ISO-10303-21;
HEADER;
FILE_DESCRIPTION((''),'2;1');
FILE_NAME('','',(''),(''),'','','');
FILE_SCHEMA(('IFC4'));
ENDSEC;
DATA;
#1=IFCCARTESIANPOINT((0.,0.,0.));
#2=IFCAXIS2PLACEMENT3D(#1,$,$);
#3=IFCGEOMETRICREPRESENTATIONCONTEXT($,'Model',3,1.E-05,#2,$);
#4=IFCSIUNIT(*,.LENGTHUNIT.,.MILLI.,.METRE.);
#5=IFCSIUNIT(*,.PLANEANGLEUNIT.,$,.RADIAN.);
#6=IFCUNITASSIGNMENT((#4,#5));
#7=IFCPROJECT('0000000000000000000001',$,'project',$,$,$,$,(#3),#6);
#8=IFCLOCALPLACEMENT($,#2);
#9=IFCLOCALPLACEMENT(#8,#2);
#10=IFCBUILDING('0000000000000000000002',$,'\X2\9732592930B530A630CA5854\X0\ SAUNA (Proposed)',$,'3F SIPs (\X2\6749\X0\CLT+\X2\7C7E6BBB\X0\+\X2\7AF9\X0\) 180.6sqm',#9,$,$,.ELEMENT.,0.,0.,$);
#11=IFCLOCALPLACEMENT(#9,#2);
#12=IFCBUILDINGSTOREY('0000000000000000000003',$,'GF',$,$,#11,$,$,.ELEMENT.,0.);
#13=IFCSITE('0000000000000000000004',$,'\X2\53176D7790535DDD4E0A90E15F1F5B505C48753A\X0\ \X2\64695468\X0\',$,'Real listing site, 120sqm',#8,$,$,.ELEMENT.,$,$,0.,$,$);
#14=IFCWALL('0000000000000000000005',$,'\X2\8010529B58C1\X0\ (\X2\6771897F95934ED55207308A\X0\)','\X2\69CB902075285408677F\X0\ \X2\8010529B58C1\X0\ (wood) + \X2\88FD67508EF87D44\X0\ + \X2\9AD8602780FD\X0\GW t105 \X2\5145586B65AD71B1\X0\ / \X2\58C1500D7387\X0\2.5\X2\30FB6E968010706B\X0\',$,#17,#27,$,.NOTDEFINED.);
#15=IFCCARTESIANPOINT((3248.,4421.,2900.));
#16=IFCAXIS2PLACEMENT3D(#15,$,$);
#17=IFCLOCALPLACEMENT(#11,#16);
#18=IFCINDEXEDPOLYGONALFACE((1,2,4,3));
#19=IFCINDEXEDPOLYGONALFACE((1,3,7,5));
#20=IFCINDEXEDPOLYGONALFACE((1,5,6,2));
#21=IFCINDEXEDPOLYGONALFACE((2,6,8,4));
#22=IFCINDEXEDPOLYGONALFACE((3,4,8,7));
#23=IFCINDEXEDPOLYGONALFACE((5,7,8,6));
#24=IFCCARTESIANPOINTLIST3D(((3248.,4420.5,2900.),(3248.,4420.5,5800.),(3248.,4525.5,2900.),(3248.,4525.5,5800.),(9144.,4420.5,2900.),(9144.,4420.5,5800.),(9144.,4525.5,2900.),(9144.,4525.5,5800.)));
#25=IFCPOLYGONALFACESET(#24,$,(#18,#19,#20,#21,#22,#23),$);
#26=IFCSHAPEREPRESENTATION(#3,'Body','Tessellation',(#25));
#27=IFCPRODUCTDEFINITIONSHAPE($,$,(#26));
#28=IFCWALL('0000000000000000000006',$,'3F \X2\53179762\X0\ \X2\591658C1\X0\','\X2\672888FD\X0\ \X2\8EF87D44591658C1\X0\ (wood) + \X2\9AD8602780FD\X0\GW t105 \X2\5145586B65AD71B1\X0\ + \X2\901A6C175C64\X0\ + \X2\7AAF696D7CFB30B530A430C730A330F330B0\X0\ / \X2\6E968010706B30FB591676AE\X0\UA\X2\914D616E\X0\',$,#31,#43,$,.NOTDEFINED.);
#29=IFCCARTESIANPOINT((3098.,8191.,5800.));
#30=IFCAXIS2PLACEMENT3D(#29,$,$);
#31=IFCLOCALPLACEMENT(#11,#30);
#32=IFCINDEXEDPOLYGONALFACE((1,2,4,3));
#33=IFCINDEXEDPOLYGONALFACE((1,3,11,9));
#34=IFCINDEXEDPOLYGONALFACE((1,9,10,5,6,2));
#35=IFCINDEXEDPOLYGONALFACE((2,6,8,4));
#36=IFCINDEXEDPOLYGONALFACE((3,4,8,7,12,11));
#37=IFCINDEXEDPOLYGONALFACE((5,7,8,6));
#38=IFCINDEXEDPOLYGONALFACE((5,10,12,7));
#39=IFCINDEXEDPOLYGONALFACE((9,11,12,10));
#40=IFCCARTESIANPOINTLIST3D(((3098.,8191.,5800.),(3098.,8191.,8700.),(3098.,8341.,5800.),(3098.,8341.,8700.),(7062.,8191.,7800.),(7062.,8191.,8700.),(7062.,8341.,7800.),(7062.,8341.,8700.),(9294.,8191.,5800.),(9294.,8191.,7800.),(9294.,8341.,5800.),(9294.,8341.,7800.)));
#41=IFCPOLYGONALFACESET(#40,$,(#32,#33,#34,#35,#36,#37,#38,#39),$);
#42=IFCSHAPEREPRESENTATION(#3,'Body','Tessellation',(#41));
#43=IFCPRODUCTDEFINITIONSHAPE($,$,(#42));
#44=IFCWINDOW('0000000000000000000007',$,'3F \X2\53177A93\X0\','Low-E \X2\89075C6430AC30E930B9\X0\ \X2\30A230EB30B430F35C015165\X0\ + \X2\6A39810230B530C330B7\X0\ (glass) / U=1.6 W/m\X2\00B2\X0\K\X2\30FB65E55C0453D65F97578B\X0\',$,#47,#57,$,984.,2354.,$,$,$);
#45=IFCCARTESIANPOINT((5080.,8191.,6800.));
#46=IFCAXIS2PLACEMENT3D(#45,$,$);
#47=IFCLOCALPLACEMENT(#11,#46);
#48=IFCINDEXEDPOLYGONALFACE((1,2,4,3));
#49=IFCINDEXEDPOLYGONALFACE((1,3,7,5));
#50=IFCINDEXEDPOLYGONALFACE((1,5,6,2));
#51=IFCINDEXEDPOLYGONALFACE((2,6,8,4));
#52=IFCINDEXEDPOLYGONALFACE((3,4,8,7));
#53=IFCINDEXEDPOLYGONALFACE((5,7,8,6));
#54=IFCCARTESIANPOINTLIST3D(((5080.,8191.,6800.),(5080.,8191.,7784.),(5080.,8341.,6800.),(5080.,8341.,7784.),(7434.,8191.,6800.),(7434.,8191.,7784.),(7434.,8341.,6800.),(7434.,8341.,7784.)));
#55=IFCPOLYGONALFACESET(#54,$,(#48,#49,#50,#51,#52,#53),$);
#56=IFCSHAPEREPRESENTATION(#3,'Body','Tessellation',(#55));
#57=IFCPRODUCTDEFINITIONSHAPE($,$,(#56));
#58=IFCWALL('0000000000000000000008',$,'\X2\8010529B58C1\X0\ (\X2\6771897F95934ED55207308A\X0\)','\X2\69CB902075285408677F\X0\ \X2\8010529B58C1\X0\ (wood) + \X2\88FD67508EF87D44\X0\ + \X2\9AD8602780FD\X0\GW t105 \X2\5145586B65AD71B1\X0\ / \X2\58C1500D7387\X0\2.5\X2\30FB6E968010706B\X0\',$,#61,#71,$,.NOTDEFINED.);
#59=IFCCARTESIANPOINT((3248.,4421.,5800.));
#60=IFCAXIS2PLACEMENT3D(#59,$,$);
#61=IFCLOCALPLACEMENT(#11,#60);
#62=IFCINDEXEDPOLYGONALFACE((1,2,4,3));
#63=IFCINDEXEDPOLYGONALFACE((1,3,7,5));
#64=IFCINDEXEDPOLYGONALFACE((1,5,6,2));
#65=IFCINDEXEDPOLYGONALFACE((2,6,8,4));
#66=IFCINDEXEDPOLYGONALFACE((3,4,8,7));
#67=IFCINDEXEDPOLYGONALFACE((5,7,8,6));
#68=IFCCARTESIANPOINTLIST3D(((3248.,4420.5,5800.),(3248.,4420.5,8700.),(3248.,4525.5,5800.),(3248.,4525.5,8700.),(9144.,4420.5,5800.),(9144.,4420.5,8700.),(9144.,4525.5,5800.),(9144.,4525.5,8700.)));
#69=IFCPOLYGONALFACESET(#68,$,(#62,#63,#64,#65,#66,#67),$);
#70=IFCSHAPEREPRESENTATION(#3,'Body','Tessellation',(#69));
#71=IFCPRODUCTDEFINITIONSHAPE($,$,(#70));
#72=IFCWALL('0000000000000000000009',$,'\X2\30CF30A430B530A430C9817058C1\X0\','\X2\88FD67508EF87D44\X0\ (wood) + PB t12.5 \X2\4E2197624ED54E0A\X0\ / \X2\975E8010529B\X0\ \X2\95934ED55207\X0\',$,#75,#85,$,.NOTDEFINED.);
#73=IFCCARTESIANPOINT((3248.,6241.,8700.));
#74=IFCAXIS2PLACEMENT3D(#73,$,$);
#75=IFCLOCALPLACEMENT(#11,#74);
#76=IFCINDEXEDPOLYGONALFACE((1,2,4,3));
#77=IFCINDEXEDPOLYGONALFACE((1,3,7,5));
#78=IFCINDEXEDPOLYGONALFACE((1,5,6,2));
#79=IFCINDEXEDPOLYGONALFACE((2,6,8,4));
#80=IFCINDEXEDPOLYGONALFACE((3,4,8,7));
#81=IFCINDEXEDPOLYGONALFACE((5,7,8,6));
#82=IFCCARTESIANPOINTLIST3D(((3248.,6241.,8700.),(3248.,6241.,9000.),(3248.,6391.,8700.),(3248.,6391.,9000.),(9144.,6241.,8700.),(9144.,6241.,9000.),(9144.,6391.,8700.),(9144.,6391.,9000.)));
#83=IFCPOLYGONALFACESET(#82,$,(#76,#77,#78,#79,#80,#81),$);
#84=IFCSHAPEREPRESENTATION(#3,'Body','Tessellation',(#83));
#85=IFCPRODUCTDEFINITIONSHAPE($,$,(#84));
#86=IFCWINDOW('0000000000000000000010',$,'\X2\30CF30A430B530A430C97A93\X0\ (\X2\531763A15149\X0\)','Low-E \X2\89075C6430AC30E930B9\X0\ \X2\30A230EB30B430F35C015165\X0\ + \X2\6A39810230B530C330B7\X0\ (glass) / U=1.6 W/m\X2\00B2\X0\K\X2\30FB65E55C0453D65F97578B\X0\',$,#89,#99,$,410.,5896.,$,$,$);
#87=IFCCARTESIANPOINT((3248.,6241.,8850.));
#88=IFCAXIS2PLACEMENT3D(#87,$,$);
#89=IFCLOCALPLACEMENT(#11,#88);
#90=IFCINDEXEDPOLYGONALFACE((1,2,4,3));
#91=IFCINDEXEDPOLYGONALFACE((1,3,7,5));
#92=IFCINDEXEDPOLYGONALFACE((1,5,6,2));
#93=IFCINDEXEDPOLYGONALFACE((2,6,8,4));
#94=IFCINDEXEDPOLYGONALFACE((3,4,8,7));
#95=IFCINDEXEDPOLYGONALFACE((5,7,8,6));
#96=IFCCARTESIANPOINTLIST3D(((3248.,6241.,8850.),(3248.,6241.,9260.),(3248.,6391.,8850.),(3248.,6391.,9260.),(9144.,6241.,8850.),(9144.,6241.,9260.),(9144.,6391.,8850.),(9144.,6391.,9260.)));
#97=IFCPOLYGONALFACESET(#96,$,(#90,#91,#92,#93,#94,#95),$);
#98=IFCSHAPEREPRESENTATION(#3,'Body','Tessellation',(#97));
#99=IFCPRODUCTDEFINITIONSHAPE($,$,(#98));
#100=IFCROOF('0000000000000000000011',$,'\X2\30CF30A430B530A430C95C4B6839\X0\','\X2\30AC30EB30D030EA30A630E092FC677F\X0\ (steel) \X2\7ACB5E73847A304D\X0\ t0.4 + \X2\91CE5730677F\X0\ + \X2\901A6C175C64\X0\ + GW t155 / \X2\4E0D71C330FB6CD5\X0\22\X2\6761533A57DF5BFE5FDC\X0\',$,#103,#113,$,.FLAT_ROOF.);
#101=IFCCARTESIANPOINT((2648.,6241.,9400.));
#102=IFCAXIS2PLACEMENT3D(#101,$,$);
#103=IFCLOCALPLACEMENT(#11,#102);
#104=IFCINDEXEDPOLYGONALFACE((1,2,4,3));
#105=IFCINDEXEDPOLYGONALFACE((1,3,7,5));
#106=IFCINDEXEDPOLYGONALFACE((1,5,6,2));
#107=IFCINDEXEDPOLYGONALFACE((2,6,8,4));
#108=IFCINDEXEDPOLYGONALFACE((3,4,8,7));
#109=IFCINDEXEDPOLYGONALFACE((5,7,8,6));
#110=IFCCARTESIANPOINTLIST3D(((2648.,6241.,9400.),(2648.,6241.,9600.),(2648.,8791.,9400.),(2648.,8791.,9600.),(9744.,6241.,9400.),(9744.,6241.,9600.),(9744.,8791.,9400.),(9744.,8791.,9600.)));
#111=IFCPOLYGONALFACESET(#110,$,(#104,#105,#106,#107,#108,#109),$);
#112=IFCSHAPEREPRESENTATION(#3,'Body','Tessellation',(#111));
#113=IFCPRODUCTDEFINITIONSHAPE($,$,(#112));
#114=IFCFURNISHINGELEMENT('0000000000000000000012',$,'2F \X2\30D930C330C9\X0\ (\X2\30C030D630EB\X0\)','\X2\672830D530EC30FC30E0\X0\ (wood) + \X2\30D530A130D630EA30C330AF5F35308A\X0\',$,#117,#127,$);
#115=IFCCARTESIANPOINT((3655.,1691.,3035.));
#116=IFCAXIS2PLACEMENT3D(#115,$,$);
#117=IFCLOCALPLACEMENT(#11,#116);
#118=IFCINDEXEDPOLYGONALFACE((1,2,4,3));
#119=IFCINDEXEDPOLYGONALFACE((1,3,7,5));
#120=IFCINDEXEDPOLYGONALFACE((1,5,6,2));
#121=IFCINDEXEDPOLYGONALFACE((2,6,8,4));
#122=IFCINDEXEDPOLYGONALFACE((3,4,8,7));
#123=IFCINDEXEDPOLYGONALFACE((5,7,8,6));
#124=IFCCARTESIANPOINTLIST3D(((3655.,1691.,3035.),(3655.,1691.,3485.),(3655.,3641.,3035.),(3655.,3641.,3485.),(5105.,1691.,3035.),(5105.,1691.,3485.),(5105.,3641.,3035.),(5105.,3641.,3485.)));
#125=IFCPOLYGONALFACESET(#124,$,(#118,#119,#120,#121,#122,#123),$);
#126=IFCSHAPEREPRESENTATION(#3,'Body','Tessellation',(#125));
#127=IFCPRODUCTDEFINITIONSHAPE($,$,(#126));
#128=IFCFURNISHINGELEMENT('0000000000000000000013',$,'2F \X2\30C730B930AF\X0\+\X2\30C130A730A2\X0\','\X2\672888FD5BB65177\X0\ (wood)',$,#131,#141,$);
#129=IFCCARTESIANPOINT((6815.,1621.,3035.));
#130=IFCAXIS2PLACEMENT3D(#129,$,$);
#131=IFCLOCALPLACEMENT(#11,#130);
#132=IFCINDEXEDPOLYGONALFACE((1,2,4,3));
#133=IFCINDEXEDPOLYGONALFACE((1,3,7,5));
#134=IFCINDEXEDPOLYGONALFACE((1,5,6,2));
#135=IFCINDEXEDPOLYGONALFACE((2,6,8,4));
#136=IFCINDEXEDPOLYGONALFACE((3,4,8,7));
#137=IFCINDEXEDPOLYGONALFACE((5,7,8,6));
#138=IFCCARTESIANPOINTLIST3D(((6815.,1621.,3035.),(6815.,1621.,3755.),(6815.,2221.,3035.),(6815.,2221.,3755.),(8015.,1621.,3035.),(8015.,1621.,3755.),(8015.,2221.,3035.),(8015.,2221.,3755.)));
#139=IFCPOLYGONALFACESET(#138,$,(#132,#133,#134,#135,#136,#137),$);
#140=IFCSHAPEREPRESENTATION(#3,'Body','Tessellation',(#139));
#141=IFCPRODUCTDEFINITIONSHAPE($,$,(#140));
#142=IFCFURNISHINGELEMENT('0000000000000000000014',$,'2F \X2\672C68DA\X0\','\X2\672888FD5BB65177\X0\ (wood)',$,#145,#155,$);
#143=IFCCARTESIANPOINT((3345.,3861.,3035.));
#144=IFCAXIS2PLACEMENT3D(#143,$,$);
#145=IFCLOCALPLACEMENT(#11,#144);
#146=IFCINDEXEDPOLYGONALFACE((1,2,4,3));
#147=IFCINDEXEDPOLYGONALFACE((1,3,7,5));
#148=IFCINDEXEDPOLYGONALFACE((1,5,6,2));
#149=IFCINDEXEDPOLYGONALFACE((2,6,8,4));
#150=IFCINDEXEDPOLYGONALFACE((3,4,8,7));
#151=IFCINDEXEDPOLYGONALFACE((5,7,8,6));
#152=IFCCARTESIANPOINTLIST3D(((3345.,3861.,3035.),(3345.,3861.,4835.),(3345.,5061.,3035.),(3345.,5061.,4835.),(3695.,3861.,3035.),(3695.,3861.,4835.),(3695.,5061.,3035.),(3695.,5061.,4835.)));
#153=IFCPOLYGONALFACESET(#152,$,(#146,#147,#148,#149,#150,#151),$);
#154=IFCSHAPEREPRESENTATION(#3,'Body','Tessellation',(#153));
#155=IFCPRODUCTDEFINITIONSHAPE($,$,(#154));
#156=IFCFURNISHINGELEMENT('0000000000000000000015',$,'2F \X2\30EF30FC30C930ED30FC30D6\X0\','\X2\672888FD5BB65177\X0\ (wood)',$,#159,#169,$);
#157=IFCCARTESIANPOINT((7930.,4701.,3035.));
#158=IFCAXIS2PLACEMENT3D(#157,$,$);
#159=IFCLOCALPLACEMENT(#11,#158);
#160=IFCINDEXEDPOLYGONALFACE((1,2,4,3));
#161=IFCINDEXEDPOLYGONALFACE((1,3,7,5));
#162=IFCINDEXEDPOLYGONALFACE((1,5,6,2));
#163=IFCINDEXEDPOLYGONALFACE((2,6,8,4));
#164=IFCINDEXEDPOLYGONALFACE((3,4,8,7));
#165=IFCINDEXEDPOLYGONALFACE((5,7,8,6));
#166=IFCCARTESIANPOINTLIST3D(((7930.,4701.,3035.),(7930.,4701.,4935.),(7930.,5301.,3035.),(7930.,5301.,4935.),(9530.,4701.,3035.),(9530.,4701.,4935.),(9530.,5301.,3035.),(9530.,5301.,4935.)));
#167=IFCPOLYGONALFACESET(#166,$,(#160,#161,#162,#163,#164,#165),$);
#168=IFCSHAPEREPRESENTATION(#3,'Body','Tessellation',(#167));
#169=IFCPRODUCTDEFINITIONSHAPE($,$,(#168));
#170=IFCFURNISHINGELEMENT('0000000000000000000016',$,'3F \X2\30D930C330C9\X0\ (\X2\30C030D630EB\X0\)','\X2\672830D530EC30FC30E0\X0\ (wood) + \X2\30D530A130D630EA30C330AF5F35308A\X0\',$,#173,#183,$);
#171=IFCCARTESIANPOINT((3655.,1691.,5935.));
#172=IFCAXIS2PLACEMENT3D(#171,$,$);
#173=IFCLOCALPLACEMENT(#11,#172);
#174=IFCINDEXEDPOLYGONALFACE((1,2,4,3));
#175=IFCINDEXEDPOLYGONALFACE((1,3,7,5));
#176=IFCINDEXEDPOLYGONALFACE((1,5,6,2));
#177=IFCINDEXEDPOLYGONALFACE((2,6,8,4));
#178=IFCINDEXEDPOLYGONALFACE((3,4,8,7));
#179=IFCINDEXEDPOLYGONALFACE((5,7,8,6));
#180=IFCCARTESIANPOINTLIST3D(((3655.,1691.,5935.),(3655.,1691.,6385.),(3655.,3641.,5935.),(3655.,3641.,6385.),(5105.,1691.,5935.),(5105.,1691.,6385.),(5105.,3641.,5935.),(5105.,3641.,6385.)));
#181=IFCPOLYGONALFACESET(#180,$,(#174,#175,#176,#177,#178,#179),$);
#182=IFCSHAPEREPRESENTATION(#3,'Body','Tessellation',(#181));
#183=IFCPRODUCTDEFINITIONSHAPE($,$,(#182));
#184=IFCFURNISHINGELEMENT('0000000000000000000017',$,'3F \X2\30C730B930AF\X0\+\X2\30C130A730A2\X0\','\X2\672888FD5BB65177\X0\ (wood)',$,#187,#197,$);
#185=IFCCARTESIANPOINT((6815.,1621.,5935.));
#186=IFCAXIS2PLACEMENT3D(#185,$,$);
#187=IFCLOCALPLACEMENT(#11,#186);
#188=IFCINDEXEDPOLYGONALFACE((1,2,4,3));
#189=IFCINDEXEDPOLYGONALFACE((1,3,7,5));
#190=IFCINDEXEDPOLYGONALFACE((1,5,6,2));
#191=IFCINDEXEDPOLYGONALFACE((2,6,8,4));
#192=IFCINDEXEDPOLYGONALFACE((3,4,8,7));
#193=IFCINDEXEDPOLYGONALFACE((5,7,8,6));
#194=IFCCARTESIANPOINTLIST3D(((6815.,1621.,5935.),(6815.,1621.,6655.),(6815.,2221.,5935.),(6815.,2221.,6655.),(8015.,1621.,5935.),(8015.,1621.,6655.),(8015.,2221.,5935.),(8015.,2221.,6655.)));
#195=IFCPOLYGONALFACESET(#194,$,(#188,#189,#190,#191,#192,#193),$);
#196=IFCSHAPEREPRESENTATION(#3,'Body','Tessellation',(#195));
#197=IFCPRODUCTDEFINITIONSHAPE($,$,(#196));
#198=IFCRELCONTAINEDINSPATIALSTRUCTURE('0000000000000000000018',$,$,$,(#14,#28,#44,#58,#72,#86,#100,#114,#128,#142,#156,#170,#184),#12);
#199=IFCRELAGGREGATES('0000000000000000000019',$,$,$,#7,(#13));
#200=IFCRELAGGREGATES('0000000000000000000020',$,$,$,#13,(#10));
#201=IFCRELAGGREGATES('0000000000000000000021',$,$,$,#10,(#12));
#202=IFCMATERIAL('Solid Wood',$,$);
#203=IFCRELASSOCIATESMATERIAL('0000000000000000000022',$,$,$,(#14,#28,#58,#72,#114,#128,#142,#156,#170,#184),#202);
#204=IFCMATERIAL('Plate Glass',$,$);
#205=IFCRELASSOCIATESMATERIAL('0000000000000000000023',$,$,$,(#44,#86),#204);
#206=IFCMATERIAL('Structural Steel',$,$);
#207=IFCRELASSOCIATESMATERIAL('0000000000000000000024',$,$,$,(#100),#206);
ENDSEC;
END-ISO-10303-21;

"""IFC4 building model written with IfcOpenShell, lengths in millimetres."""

from ifc_helpers import new_model, si_unit, frame, frame_2d, origin, place, context, project, spatial, rectangle, extrude, material, element, fill, save


model = new_model("IFC4")

# Units and contexts
model_context = context("Model", 3, precision=1e-05, world=origin())
ifc_project = project(units=[si_unit("LENGTHUNIT", "METRE", prefix="MILLI"), si_unit("PLANEANGLEUNIT", "RADIAN")], contexts=[model_context])

# Site, building, storey
site_placement = place(None, origin())
site = spatial("IfcSite", under=ifc_project, at=site_placement, Name="北海道川上郡弟子屈町 摩周", ObjectType="Real listing site, 120sqm", CompositionType="ELEMENT", RefElevation=0.0)
building_placement = place(site_placement, origin())
building = spatial("IfcBuilding", under=site, at=building_placement, Name="露天サウナ塔 SAUNA (Proposed)", ObjectType="3F SIPs (杉CLT+籾殻+竹) 180.6sqm", CompositionType="ELEMENT", ElevationOfRefHeight=0.0, ElevationOfTerrain=0.0)
storey_placement = place(building_placement, origin())
storey = spatial("IfcBuildingStorey", under=building, at=storey_placement, Name="GF", CompositionType="ELEMENT", Elevation=0.0)

# Wall
ifc_material_1 = material(Name="Solid Wood")
wall_1_placement = place(storey_placement, frame((3248.0, 4421.0, 2900.0)))
element("IfcWall", 1, at=wall_1_placement, inside=storey, material=ifc_material_1, Name="耐力壁 (東西間仕切り)", Description="構造用合板 耐力壁 (wood) + 製材軸組 + 高性能GW t105 充填断熱 / 壁倍率2.5・準耐火", PredefinedType="NOTDEFINED", context=model_context, shape_type="SweptSolid", body=[
    extrude(rectangle(XDim=5896.0, YDim=105.0, at=frame_2d((2948.0, 52.0))), frame((3248.0, 4421.0, 2900.0)), (0.0, 0.0, 1.0), 2900.0),
])

# Wall, opening, window
wall_2_placement = place(storey_placement, frame((3098.0, 8191.0, 5800.0)))
wall_2 = element("IfcWall", 2, at=wall_2_placement, inside=storey, material=ifc_material_1, Name="3F 北面 外壁", Description="木製 軸組外壁 (wood) + 高性能GW t105 充填断熱 + 通気層 + 窯業系サイディング / 準耐火・外皮UA配慮", PredefinedType="NOTDEFINED", context=model_context, shape_type="SweptSolid", body=[
    extrude(rectangle(XDim=6196.0, YDim=150.0, at=frame_2d((3098.0, 75.0))), frame((3098.0, 8191.0, 5800.0)), (0.0, 0.0, 1.0), 2900.0),
])
opening_1_placement = place(storey_placement, frame((5080.0, 8191.0, 6800.0)))
opening_1 = element("IfcOpeningElement", 3, at=opening_1_placement, cuts=wall_2, PredefinedType="NOTDEFINED", context=model_context, shape_type="SweptSolid", body=[
    extrude(rectangle(XDim=2354.0, YDim=150.0, at=frame_2d((1177.0, 75.0))), frame((5080.0, 8191.0, 6800.0)), (0.0, 0.0, 1.0), 984.0),
])
ifc_material_2 = material(Name="Plate Glass")
window_1_placement = place(storey_placement, frame((5080.0, 8191.0, 6800.0)))
window_1 = element("IfcWindow", 4, at=window_1_placement, inside=storey, material=ifc_material_2, Name="3F 北窓", Description="Low-E 複層ガラス アルゴン封入 + 樹脂サッシ (glass) / U=1.6 W/m²K・日射取得型", OverallHeight=984.0, OverallWidth=2354.0, context=model_context, shape_type="SweptSolid", body=[
    extrude(rectangle(XDim=2354.0, YDim=150.0, at=frame_2d((1177.0, 75.0))), frame((5080.0, 8191.0, 6800.0)), (0.0, 0.0, 1.0), 984.0),
])
fill(opening_1, window_1)

# Wall
wall_3_placement = place(storey_placement, frame((3248.0, 4421.0, 5800.0)))
element("IfcWall", 5, at=wall_3_placement, inside=storey, material=ifc_material_1, Name="耐力壁 (東西間仕切り)", Description="構造用合板 耐力壁 (wood) + 製材軸組 + 高性能GW t105 充填断熱 / 壁倍率2.5・準耐火", PredefinedType="NOTDEFINED", context=model_context, shape_type="SweptSolid", body=[
    extrude(rectangle(XDim=5896.0, YDim=105.0, at=frame_2d((2948.0, 52.0))), frame((3248.0, 4421.0, 5800.0)), (0.0, 0.0, 1.0), 2900.0),
])

# Wall, opening, window
wall_4_placement = place(storey_placement, frame((3248.0, 6241.0, 8700.0)))
wall_4 = element("IfcWall", 6, at=wall_4_placement, inside=storey, material=ifc_material_1, Name="ハイサイド腰壁", Description="製材軸組 (wood) + PB t12.5 両面仕上 / 非耐力 間仕切", PredefinedType="NOTDEFINED", context=model_context, shape_type="SweptSolid", body=[
    extrude(rectangle(XDim=5896.0, YDim=150.0, at=frame_2d((2948.0, 75.0))), frame((3248.0, 6241.0, 8700.0)), (0.0, 0.0, 1.0), 700.0),
])
opening_2_placement = place(storey_placement, frame((3248.0, 6241.0, 8850.0)))
opening_2 = element("IfcOpeningElement", 7, at=opening_2_placement, cuts=wall_4, PredefinedType="NOTDEFINED", context=model_context, shape_type="SweptSolid", body=[
    extrude(rectangle(XDim=5896.0, YDim=150.0, at=frame_2d((2948.0, 75.0))), frame((3248.0, 6241.0, 8850.0)), (0.0, 0.0, 1.0), 410.0),
])
window_2_placement = place(storey_placement, frame((3248.0, 6241.0, 8850.0)))
window_2 = element("IfcWindow", 8, at=window_2_placement, inside=storey, material=ifc_material_2, Name="ハイサイド窓 (北採光)", Description="Low-E 複層ガラス アルゴン封入 + 樹脂サッシ (glass) / U=1.6 W/m²K・日射取得型", OverallHeight=410.0, OverallWidth=5896.0, context=model_context, shape_type="SweptSolid", body=[
    extrude(rectangle(XDim=5896.0, YDim=150.0, at=frame_2d((2948.0, 75.0))), frame((3248.0, 6241.0, 8850.0)), (0.0, 0.0, 1.0), 410.0),
])
fill(opening_2, window_2)

# Roof
ifc_material_3 = material(Name="Structural Steel")
roof_placement = place(storey_placement, frame((2648.0, 6241.0, 9400.0)))
element("IfcRoof", 9, at=roof_placement, inside=storey, material=ifc_material_3, Name="ハイサイド屋根", Description="ガルバリウム鋼板 (steel) 立平葺き t0.4 + 野地板 + 通気層 + GW t155 / 不燃・法22条区域対応", PredefinedType="FLAT_ROOF", context=model_context, shape_type="SweptSolid", body=[
    extrude(rectangle(XDim=7096.0, YDim=2550.0, at=frame_2d((3548.0, 1275.0))), frame((2648.0, 6241.0, 9400.0)), (0.0, 0.0, 1.0), 200.0),
])

# Furnishing elements
furnishing_1_placement = place(storey_placement, frame((3655.0, 1691.0, 3035.0)))
element("IfcFurnishingElement", 10, at=furnishing_1_placement, inside=storey, material=ifc_material_1, Name="2F ベッド (ダブル)", Description="木フレーム (wood) + ファブリック張り", context=model_context, shape_type="SweptSolid", body=[
    extrude(rectangle(XDim=1450.0, YDim=1950.0, at=frame_2d((725.0, 975.0))), frame((3655.0, 1691.0, 3035.0)), (0.0, 0.0, 1.0), 450.0),
])
furnishing_2_placement = place(storey_placement, frame((6815.0, 1621.0, 3035.0)))
element("IfcFurnishingElement", 11, at=furnishing_2_placement, inside=storey, material=ifc_material_1, Name="2F デスク+チェア", Description="木製家具 (wood)", context=model_context, shape_type="SweptSolid", body=[
    extrude(rectangle(XDim=1200.0, YDim=600.0, at=frame_2d((600.0, 300.0))), frame((6815.0, 1621.0, 3035.0)), (0.0, 0.0, 1.0), 720.0),
])
furnishing_3_placement = place(storey_placement, frame((3345.0, 3861.0, 3035.0)))
element("IfcFurnishingElement", 12, at=furnishing_3_placement, inside=storey, material=ifc_material_1, Name="2F 本棚", Description="木製家具 (wood)", context=model_context, shape_type="SweptSolid", body=[
    extrude(rectangle(XDim=350.0, YDim=1200.0, at=frame_2d((175.0, 600.0))), frame((3345.0, 3861.0, 3035.0)), (0.0, 0.0, 1.0), 1800.0),
])
furnishing_4_placement = place(storey_placement, frame((7930.0, 4701.0, 3035.0)))
element("IfcFurnishingElement", 13, at=furnishing_4_placement, inside=storey, material=ifc_material_1, Name="2F ワードローブ", Description="木製家具 (wood)", context=model_context, shape_type="SweptSolid", body=[
    extrude(rectangle(XDim=1600.0, YDim=600.0, at=frame_2d((800.0, 300.0))), frame((7930.0, 4701.0, 3035.0)), (0.0, 0.0, 1.0), 1900.0),
])
furnishing_5_placement = place(storey_placement, frame((3655.0, 1691.0, 5935.0)))
element("IfcFurnishingElement", 14, at=furnishing_5_placement, inside=storey, material=ifc_material_1, Name="3F ベッド (ダブル)", Description="木フレーム (wood) + ファブリック張り", context=model_context, shape_type="SweptSolid", body=[
    extrude(rectangle(XDim=1450.0, YDim=1950.0, at=frame_2d((725.0, 975.0))), frame((3655.0, 1691.0, 5935.0)), (0.0, 0.0, 1.0), 450.0),
])
furnishing_6_placement = place(storey_placement, frame((6815.0, 1621.0, 5935.0)))
element("IfcFurnishingElement", 15, at=furnishing_6_placement, inside=storey, material=ifc_material_1, Name="3F デスク+チェア", Description="木製家具 (wood)", context=model_context, shape_type="SweptSolid", body=[
    extrude(rectangle(XDim=1200.0, YDim=600.0, at=frame_2d((600.0, 300.0))), frame((6815.0, 1621.0, 5935.0)), (0.0, 0.0, 1.0), 720.0),
])

save(model, "model.ifc")
